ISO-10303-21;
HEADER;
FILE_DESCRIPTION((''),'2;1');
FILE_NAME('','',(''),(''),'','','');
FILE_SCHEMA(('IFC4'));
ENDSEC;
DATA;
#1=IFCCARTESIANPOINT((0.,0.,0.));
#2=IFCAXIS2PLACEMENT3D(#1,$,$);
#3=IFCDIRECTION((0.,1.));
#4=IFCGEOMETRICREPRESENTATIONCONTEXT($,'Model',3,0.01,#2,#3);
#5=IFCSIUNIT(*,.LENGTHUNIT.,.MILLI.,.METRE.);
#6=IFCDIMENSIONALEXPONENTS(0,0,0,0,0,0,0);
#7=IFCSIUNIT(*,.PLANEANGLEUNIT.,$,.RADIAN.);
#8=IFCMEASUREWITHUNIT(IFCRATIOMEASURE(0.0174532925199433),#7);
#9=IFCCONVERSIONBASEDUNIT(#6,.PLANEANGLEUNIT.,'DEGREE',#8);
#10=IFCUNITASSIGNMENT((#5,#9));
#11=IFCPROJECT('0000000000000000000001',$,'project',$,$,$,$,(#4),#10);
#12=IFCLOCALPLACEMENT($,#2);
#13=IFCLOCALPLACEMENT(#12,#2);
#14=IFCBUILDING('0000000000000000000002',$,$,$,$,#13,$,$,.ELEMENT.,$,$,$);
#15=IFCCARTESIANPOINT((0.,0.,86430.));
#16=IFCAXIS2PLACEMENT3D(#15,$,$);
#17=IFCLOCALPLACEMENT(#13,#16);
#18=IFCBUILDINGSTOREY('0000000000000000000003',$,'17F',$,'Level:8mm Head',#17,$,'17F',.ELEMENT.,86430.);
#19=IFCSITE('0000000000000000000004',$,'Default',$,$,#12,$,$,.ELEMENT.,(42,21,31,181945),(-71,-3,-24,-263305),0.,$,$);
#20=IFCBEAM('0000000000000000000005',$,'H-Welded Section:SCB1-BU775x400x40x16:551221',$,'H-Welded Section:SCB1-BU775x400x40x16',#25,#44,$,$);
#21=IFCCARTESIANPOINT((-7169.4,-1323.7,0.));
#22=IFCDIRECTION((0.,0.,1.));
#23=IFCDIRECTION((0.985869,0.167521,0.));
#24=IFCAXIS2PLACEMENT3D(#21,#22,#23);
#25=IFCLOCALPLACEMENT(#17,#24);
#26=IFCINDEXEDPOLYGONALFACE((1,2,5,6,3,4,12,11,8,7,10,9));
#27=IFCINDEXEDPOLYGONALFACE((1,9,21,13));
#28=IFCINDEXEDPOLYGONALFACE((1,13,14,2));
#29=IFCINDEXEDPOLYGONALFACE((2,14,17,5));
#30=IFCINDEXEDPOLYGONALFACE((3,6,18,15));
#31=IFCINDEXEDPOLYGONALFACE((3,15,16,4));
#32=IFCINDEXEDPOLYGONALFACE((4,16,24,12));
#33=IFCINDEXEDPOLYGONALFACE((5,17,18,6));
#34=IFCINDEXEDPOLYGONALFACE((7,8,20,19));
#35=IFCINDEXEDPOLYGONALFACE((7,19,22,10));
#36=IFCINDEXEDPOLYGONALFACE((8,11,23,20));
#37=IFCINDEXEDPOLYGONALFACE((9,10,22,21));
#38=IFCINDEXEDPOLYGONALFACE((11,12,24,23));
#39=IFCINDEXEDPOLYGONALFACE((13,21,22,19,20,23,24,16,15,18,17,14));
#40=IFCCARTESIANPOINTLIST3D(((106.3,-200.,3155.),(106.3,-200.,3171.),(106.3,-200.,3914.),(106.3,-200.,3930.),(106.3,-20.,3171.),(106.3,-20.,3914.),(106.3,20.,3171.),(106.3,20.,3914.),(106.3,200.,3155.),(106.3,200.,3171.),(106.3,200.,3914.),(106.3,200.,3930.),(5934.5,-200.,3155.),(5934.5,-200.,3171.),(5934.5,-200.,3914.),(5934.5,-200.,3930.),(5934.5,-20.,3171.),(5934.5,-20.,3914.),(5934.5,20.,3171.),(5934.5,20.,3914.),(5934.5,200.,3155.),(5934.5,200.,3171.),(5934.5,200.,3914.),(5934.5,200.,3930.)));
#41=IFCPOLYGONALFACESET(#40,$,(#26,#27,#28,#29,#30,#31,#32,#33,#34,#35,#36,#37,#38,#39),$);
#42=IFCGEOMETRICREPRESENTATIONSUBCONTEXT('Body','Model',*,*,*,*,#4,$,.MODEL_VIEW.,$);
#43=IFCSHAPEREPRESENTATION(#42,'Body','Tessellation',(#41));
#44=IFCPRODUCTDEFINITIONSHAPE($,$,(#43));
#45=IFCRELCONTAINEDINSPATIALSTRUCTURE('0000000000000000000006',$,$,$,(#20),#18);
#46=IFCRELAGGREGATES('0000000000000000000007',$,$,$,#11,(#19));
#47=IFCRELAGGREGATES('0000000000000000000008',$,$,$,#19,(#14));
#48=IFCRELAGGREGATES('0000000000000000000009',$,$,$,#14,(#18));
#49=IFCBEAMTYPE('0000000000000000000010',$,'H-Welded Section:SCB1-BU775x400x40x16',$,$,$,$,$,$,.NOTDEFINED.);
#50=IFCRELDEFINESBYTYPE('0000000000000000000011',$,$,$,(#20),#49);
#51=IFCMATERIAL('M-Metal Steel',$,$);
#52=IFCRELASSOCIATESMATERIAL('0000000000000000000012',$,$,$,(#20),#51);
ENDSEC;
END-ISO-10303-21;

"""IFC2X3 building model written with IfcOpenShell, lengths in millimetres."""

from ifc_helpers import new_model, entity, si_unit, converted_unit, direction, frame, frame_2d, origin, place, context, subcontext, project, spatial, i_section, extrude, material, type_object, element, save


model = new_model("IFC2X3")

# Units and contexts
model_context = context("Model", 3, precision=0.01, world=origin(), true_north=direction((0.0, 1.0)))
body_context = subcontext(model_context, "Body", "Model", "MODEL_VIEW")
ifc_project = project(units=[si_unit("LENGTHUNIT", "METRE", prefix="MILLI"), converted_unit("PLANEANGLEUNIT", "DEGREE", entity("IfcRatioMeasure", 0.0174532925199433), si_unit("PLANEANGLEUNIT", "RADIAN"), dimensions=[0, 0, 0, 0, 0, 0, 0])], contexts=[model_context])

# Site, building, storey
site_placement = place(None, origin())
site = spatial("IfcSite", under=ifc_project, at=site_placement, Name="Default", CompositionType="ELEMENT", RefLatitude=(42, 21, 31, 181945), RefLongitude=(-71, -3, -24, -263305), RefElevation=0.0)
building_placement = place(site_placement, origin())
building = spatial("IfcBuilding", under=site, at=building_placement, CompositionType="ELEMENT")
storey_placement = place(building_placement, frame((0.0, 0.0, 86430.0)))
storey = spatial("IfcBuildingStorey", under=building, at=storey_placement, Name="17F", ObjectType="Level:8mm Head", LongName="17F", CompositionType="ELEMENT", Elevation=86430.0)

# Beam
ifc_material_1 = material(Name="M-Metal Steel")
beam_type_1 = type_object("IfcBeamType", Name="H-Welded Section:SCB1-BU775x400x40x16", PredefinedType="NOTDEFINED")
beam_1_placement = place(storey_placement, frame((-7169.4, -1323.7, 0.0), z_axis=(0.0, 0.0, 1.0), x_axis=(0.985869, 0.167521, 0.0)))
element("IfcBeam", 1, at=beam_1_placement, inside=storey, type_object=beam_type_1, material=ifc_material_1, Name="H-Welded Section:SCB1-BU775x400x40x16:551221", ObjectType="H-Welded Section:SCB1-BU775x400x40x16", context=body_context, shape_type="SweptSolid", body=[
    extrude(i_section(OverallWidth=400.0, OverallDepth=775.0, WebThickness=40.0, FlangeThickness=16.0, at=frame_2d((0.0, 0.0), x_axis=(0.0, 1.0))), frame((106.3, 0.0, 3542.5), z_axis=(1.0, 0.0, 0.0), x_axis=(0.0, 0.0, -1.0)), (0.0, 0.0, 1.0), 5828.1),
])

save(model, "model.ifc")
